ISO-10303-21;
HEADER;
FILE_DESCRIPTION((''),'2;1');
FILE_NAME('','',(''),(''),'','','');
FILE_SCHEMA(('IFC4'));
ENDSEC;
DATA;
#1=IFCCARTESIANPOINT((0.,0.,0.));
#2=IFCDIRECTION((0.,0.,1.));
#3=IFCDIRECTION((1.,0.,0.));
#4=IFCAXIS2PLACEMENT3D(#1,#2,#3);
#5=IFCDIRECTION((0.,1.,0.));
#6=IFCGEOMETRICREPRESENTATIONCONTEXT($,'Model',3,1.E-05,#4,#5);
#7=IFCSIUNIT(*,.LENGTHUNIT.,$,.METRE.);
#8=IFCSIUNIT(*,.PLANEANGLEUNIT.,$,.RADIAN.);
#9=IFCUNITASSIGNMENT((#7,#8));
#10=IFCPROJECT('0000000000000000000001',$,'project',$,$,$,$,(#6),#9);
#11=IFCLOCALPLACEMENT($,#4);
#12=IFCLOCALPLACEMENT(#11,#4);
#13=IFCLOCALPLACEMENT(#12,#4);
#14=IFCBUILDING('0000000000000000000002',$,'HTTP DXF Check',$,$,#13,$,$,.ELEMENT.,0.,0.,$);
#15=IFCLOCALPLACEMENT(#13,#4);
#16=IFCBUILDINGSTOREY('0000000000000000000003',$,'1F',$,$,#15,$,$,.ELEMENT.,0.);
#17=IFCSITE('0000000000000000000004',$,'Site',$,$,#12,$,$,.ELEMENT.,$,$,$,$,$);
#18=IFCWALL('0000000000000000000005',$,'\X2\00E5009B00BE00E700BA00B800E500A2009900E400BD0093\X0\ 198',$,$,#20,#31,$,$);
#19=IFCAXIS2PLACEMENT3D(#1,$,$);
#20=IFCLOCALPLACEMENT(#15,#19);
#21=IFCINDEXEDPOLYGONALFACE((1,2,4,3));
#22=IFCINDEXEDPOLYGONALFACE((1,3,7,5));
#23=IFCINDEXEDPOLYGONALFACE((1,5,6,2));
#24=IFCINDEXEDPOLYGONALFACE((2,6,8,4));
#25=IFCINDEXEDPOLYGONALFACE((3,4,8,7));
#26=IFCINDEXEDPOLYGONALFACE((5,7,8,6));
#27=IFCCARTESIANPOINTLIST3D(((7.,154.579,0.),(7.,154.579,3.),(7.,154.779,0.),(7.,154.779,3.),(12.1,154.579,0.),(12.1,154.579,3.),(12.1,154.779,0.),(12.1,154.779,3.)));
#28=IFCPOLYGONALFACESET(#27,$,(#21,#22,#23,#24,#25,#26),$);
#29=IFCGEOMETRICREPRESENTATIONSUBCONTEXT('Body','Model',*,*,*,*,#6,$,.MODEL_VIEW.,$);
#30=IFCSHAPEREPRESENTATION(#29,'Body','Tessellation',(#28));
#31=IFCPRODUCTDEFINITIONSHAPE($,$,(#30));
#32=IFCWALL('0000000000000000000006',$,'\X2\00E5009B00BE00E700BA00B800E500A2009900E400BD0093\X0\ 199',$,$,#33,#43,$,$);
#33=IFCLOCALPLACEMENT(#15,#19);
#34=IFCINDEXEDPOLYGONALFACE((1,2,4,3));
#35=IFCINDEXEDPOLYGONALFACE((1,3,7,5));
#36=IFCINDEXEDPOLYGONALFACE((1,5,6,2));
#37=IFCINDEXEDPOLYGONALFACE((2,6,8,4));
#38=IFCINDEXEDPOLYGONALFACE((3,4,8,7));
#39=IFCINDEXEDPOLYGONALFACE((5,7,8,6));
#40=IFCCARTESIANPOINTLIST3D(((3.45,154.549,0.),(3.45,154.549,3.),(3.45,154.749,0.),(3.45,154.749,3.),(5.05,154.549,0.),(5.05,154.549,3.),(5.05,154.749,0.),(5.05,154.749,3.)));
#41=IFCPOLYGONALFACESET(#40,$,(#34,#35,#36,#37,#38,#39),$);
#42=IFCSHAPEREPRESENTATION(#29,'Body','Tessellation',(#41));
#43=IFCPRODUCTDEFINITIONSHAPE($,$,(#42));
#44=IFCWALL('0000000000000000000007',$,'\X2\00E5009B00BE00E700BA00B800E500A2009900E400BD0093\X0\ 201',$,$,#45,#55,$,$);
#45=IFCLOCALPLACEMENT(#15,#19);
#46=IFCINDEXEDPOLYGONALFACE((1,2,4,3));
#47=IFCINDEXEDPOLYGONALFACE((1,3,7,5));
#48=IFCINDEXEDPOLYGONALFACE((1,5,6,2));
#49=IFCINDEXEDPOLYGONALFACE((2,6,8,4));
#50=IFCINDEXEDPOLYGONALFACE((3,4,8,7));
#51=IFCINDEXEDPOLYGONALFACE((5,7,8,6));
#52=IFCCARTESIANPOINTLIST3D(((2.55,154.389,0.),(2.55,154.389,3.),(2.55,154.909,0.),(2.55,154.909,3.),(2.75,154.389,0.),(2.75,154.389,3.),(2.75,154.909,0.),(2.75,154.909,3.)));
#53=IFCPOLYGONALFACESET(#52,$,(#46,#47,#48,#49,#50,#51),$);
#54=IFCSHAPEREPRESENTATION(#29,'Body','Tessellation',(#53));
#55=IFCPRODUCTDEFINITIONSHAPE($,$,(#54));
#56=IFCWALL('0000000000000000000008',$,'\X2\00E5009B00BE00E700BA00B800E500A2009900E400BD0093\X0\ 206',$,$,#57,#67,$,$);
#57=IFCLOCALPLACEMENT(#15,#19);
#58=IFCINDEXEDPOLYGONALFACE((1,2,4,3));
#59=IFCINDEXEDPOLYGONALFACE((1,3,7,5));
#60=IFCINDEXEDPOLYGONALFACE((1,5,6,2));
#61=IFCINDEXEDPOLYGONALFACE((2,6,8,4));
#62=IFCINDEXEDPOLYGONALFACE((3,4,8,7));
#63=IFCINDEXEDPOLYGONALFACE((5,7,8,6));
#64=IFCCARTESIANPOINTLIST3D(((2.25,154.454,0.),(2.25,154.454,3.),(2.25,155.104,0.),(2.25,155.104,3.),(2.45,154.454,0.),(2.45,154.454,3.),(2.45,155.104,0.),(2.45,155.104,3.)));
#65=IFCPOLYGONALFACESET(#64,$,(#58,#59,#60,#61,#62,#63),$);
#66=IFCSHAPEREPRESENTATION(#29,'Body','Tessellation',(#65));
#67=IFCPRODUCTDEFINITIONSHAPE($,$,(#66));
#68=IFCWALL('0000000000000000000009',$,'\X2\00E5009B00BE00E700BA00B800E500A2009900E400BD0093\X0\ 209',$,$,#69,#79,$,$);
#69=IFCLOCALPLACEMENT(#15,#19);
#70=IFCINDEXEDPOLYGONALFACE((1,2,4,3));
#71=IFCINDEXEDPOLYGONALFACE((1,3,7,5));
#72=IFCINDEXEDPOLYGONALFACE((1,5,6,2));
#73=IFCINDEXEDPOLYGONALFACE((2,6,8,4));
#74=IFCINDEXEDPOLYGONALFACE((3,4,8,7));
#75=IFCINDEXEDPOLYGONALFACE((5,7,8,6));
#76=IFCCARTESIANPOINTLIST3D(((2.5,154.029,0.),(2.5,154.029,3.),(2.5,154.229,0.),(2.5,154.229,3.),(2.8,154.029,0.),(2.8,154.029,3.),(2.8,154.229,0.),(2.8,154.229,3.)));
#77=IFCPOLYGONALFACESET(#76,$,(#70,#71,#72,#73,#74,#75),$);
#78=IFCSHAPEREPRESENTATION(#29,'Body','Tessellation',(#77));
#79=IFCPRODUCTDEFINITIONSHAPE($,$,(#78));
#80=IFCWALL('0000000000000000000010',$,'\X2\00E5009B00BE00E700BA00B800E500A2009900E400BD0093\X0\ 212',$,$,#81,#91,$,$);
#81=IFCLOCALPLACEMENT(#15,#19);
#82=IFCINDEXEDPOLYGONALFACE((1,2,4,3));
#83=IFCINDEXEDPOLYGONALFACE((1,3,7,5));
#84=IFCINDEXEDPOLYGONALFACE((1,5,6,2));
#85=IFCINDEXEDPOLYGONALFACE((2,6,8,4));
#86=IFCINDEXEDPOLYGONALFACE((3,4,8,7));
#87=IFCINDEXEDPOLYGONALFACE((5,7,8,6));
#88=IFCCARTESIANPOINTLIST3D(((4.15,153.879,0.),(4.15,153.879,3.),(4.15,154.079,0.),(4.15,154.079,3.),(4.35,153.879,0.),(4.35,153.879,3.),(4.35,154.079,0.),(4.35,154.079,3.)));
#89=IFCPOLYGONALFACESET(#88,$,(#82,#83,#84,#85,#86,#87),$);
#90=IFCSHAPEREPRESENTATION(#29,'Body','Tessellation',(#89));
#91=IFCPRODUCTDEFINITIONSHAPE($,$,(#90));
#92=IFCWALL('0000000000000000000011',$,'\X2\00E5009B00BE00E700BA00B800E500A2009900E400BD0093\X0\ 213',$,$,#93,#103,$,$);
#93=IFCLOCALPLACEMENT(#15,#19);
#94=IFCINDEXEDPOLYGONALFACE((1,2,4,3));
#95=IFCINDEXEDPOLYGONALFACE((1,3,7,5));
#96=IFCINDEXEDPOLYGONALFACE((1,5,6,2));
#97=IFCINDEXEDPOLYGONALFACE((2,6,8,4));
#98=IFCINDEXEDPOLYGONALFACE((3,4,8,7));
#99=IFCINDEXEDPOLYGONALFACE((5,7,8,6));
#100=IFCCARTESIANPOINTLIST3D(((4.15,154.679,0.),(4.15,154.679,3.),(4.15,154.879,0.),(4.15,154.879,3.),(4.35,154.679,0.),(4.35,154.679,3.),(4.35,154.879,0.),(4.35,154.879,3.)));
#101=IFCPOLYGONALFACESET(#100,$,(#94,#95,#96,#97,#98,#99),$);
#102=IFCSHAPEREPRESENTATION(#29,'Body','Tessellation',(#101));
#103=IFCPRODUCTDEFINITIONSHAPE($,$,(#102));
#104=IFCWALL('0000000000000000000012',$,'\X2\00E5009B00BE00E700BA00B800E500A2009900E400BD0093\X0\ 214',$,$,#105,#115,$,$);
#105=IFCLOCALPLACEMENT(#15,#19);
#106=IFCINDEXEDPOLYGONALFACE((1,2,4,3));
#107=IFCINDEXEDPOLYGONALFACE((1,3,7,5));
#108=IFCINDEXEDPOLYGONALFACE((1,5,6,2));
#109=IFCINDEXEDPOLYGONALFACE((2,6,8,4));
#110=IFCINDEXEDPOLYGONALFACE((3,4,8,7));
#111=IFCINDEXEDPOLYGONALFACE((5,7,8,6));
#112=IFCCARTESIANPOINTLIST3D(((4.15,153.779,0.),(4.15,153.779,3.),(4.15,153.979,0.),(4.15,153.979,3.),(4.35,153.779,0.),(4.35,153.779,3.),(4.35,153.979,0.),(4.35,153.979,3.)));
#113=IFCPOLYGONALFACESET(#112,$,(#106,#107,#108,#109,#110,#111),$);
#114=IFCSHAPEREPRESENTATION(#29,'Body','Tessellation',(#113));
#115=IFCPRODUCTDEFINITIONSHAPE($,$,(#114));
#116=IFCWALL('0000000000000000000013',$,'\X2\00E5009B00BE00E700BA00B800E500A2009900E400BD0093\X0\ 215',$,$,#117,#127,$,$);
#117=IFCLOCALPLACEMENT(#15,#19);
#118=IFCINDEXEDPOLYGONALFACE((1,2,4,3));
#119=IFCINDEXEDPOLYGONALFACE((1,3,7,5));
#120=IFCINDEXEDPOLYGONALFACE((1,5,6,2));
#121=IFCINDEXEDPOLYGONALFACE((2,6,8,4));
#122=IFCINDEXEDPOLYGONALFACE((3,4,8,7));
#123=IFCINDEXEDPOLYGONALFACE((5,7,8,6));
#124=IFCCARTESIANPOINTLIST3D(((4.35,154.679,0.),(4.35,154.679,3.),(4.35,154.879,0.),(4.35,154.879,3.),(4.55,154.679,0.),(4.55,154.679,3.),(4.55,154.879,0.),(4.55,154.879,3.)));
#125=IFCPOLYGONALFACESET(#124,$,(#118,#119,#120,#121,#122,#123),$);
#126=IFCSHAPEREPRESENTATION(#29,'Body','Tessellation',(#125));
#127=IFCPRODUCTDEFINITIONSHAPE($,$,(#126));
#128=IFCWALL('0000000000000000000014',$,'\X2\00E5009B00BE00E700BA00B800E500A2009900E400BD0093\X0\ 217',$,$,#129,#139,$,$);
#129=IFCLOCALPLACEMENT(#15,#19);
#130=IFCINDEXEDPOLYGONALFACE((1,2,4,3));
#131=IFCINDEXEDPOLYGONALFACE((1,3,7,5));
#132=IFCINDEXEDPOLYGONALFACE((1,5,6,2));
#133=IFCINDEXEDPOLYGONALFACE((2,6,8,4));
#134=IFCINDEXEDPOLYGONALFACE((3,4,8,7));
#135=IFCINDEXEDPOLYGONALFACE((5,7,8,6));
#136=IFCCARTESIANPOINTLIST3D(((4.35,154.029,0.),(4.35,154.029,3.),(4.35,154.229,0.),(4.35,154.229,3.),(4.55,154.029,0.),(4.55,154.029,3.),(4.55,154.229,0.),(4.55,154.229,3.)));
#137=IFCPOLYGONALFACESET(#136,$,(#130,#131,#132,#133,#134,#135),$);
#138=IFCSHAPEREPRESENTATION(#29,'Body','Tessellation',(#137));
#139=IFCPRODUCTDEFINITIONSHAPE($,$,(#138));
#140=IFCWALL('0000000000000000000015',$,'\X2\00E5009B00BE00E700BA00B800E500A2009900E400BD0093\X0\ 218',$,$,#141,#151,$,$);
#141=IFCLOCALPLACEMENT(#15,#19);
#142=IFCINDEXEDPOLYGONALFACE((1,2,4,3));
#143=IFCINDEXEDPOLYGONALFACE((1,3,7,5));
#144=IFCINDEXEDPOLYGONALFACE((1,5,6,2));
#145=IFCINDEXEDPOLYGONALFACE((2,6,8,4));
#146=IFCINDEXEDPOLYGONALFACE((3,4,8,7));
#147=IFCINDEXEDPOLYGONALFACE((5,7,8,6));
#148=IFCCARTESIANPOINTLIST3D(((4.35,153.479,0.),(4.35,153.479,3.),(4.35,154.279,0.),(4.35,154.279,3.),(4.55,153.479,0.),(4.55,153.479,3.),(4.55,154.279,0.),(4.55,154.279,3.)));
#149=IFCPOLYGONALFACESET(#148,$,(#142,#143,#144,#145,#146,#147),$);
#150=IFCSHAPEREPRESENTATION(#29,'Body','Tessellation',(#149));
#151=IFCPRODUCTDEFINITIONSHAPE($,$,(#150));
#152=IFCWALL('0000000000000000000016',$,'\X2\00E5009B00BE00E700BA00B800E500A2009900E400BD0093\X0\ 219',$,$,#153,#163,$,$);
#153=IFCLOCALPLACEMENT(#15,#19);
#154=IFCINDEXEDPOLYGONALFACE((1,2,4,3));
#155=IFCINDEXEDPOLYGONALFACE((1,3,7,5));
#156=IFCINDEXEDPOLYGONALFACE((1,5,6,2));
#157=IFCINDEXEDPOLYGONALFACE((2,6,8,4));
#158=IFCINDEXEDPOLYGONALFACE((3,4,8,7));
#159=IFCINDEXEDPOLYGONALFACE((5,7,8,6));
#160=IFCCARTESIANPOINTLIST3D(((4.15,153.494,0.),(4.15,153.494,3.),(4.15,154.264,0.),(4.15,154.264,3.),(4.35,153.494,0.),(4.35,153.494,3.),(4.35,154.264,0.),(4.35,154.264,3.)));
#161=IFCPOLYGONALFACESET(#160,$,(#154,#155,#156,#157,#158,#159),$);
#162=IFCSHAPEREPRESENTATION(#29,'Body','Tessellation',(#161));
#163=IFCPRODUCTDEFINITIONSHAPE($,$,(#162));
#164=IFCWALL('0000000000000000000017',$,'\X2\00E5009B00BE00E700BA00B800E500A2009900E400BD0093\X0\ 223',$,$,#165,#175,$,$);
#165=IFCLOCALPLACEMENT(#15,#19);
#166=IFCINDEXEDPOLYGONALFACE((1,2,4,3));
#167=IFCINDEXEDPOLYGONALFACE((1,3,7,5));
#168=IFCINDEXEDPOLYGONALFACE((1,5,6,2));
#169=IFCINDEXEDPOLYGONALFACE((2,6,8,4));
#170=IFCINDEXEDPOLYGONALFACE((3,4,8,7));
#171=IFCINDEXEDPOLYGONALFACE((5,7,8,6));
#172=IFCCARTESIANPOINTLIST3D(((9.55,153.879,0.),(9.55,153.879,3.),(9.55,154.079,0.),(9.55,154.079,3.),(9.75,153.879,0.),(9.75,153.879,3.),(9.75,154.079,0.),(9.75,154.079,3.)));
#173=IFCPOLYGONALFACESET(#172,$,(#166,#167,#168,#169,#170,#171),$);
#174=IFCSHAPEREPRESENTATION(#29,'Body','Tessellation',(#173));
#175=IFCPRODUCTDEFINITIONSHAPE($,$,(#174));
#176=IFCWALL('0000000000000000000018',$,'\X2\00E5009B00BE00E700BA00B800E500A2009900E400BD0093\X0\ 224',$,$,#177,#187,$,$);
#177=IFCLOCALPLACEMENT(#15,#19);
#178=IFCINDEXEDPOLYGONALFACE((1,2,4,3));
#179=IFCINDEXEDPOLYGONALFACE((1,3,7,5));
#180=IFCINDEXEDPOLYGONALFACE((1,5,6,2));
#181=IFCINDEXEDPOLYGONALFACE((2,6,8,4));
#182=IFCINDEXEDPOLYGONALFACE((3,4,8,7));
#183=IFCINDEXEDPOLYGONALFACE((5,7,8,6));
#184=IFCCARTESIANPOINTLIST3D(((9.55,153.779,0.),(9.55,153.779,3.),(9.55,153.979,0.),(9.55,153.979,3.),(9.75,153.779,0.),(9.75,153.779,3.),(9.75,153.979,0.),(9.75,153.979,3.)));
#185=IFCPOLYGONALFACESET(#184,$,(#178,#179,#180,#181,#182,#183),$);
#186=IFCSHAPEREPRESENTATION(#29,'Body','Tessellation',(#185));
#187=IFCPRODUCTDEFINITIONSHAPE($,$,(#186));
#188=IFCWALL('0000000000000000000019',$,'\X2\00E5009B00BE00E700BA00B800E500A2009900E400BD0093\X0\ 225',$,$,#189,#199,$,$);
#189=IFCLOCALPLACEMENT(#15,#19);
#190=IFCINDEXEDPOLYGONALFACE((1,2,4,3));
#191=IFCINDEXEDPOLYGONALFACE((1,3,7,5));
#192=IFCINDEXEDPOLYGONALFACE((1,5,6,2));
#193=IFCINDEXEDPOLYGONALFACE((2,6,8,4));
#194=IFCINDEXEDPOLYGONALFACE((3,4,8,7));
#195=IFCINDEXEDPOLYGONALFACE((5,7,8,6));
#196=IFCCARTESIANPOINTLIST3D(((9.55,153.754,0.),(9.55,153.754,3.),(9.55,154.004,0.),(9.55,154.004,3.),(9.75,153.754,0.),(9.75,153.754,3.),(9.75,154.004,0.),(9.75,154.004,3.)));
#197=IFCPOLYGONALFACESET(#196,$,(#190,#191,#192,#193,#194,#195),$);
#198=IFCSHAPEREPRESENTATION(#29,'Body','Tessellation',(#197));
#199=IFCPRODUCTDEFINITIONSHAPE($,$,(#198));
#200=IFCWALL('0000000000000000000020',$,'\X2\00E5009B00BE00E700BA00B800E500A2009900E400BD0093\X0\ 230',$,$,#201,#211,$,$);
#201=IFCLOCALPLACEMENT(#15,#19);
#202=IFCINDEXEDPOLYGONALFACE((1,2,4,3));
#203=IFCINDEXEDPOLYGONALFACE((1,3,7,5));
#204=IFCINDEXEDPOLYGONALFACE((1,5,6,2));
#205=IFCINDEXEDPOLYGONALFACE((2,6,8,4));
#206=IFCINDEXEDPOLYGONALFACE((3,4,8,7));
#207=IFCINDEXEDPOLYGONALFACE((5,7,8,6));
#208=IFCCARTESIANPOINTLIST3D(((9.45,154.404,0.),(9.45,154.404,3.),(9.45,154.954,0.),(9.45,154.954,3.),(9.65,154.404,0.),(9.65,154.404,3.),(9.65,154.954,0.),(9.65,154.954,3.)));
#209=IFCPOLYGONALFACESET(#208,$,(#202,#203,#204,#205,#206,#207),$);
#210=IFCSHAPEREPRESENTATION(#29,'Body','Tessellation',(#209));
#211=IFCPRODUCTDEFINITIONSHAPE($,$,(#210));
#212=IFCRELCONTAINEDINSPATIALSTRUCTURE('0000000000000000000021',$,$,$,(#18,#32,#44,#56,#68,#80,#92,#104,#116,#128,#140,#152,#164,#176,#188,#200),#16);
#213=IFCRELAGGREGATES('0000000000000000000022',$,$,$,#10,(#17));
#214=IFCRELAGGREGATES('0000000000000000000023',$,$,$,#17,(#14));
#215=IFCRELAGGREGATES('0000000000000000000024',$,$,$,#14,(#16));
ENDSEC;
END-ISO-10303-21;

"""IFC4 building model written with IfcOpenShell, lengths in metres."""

from ifc_helpers import new_model, si_unit, direction, frame, frame_2d, origin_with_axes, place, context, subcontext, project, spatial, rectangle, extrude, element, save


model = new_model("IFC4")

# Units and contexts
model_context = context("Model", 3, precision=1e-05, world=origin_with_axes(), true_north=direction((0.0, 1.0, 0.0)))
body_context = subcontext(model_context, "Body", "Model", "MODEL_VIEW")
ifc_project = project(units=[si_unit("LENGTHUNIT", "METRE"), si_unit("PLANEANGLEUNIT", "RADIAN")], contexts=[model_context])

# Site, building, storey
placement = place(None, origin_with_axes())
site_placement = place(placement, origin_with_axes())
site = spatial("IfcSite", under=ifc_project, at=site_placement, Name="Site", CompositionType="ELEMENT")
building_placement = place(site_placement, origin_with_axes())
building = spatial("IfcBuilding", under=site, at=building_placement, Name="HTTP DXF Check", CompositionType="ELEMENT", ElevationOfRefHeight=0.0, ElevationOfTerrain=0.0)
storey_placement = place(building_placement, origin_with_axes())
storey = spatial("IfcBuildingStorey", under=building, at=storey_placement, Name="1F", CompositionType="ELEMENT", Elevation=0.0)

# Walls
wall_1_placement = place(storey_placement, frame((9.55, 154.679, 0.0), z_axis=(0.0, 0.0, 1.0), x_axis=(-1.0, 0.0, 0.0)))
element("IfcWall", 1, at=wall_1_placement, inside=storey, Name="å\u009b¾çº¸å¢\u0099ä½\u0093 198", context=body_context, shape_type="SweptSolid", body=[
    extrude(rectangle(XDim=5.1, YDim=0.2, at=frame_2d((0.0, 0.0), x_axis=(1.0, 0.0, 0.0))), frame((0.0, 0.0, 0.0), z_axis=(0.0, 0.0, 1.0)), (0.0, 0.0, 1.0), 3.0),
])
wall_2_placement = place(storey_placement, frame((4.25, 154.649, 0.0), z_axis=(0.0, 0.0, 1.0), x_axis=(-1.0, 0.0, 0.0)))
element("IfcWall", 2, at=wall_2_placement, inside=storey, Name="å\u009b¾çº¸å¢\u0099ä½\u0093 199", context=body_context, shape_type="SweptSolid", body=[
    extrude(rectangle(XDim=1.6, YDim=0.2, at=frame_2d((0.0, 0.0), x_axis=(1.0, 0.0, 0.0))), frame((0.0, 0.0, 0.0), z_axis=(0.0, 0.0, 1.0)), (0.0, 0.0, 1.0), 3.0),
])
wall_3_placement = place(storey_placement, frame((2.65, 154.649, 0.0), z_axis=(0.0, 0.0, 1.0), x_axis=(0.0, -1.0, 0.0)))
element("IfcWall", 3, at=wall_3_placement, inside=storey, Name="å\u009b¾çº¸å¢\u0099ä½\u0093 201", context=body_context, shape_type="SweptSolid", body=[
    extrude(rectangle(XDim=0.52, YDim=0.2, at=frame_2d((0.0, 0.0), x_axis=(1.0, 0.0, 0.0))), frame((0.0, 0.0, 0.0), z_axis=(0.0, 0.0, 1.0)), (0.0, 0.0, 1.0), 3.0),
])
wall_4_placement = place(storey_placement, frame((2.35, 154.779, 0.0), z_axis=(0.0, 0.0, 1.0), x_axis=(0.0, -1.0, 0.0)))
element("IfcWall", 4, at=wall_4_placement, inside=storey, Name="å\u009b¾çº¸å¢\u0099ä½\u0093 206", context=body_context, shape_type="SweptSolid", body=[
    extrude(rectangle(XDim=0.65, YDim=0.2, at=frame_2d((0.0, 0.0), x_axis=(1.0, 0.0, 0.0))), frame((0.0, 0.0, 0.0), z_axis=(0.0, 0.0, 1.0)), (0.0, 0.0, 1.0), 3.0),
])
wall_5_placement = place(storey_placement, frame((2.65, 154.129, 0.0), z_axis=(0.0, 0.0, 1.0), x_axis=(-1.0, 0.0, 0.0)))
element("IfcWall", 5, at=wall_5_placement, inside=storey, Name="å\u009b¾çº¸å¢\u0099ä½\u0093 209", context=body_context, shape_type="SweptSolid", body=[
    extrude(rectangle(XDim=0.3, YDim=0.2, at=frame_2d((0.0, 0.0), x_axis=(1.0, 0.0, 0.0))), frame((0.0, 0.0, 0.0), z_axis=(0.0, 0.0, 1.0)), (0.0, 0.0, 1.0), 3.0),
])
for number, where, z_axis, x_axis, name in (
    (6, (4.25, 153.979, 0.0), (0.0, 0.0, 1.0), (1.0, 0.0, 0.0), "å\u009b¾çº¸å¢\u0099ä½\u0093 212"),
    (7, (4.25, 154.779, 0.0), (0.0, 0.0, 1.0), (1.0, 0.0, 0.0), "å\u009b¾çº¸å¢\u0099ä½\u0093 213"),
    (8, (4.25, 153.879, 0.0), (0.0, 0.0, 1.0), (1.0, 0.0, 0.0), "å\u009b¾çº¸å¢\u0099ä½\u0093 214"),
    (9, (4.45, 154.779, 0.0), (0.0, 0.0, 1.0), (-1.0, 0.0, 0.0), "å\u009b¾çº¸å¢\u0099ä½\u0093 215"),
    (10, (4.45, 154.129, 0.0), (0.0, 0.0, 1.0), (-1.0, 0.0, 0.0), "å\u009b¾çº¸å¢\u0099ä½\u0093 217"),
):
    element("IfcWall", number, at=place(storey_placement, frame(where, z_axis=z_axis, x_axis=x_axis)), inside=storey, Name=name, context=body_context, shape_type="SweptSolid", body=[
        extrude(rectangle(XDim=0.2, YDim=0.2, at=frame_2d((0.0, 0.0), x_axis=(1.0, 0.0, 0.0))), frame((0.0, 0.0, 0.0), z_axis=(0.0, 0.0, 1.0)), (0.0, 0.0, 1.0), 3.0),
    ])
wall_6_placement = place(storey_placement, frame((4.45, 153.879, 0.0), z_axis=(0.0, 0.0, 1.0), x_axis=(0.0, 1.0, 0.0)))
element("IfcWall", 11, at=wall_6_placement, inside=storey, Name="å\u009b¾çº¸å¢\u0099ä½\u0093 218", context=body_context, shape_type="SweptSolid", body=[
    extrude(rectangle(XDim=0.8, YDim=0.2, at=frame_2d((0.0, 0.0), x_axis=(1.0, 0.0, 0.0))), frame((0.0, 0.0, 0.0), z_axis=(0.0, 0.0, 1.0)), (0.0, 0.0, 1.0), 3.0),
])
wall_7_placement = place(storey_placement, frame((4.25, 153.879, 0.0), z_axis=(0.0, 0.0, 1.0), x_axis=(0.0, 1.0, 0.0)))
element("IfcWall", 12, at=wall_7_placement, inside=storey, Name="å\u009b¾çº¸å¢\u0099ä½\u0093 219", context=body_context, shape_type="SweptSolid", body=[
    extrude(rectangle(XDim=0.77, YDim=0.2, at=frame_2d((0.0, 0.0), x_axis=(1.0, 0.0, 0.0))), frame((0.0, 0.0, 0.0), z_axis=(0.0, 0.0, 1.0)), (0.0, 0.0, 1.0), 3.0),
])
for number, where, z_axis, x_axis, name in (
    (13, (9.65, 153.979, 0.0), (0.0, 0.0, 1.0), (1.0, 0.0, 0.0), "å\u009b¾çº¸å¢\u0099ä½\u0093 223"),
    (14, (9.65, 153.879, 0.0), (0.0, 0.0, 1.0), (1.0, 0.0, 0.0), "å\u009b¾çº¸å¢\u0099ä½\u0093 224"),
):
    element("IfcWall", number, at=place(storey_placement, frame(where, z_axis=z_axis, x_axis=x_axis)), inside=storey, Name=name, context=body_context, shape_type="SweptSolid", body=[
        extrude(rectangle(XDim=0.2, YDim=0.2, at=frame_2d((0.0, 0.0), x_axis=(1.0, 0.0, 0.0))), frame((0.0, 0.0, 0.0), z_axis=(0.0, 0.0, 1.0)), (0.0, 0.0, 1.0), 3.0),
    ])
wall_8_placement = place(storey_placement, frame((9.65, 153.879, 0.0), z_axis=(0.0, 0.0, 1.0), x_axis=(0.0, 1.0, 0.0)))
element("IfcWall", 15, at=wall_8_placement, inside=storey, Name="å\u009b¾çº¸å¢\u0099ä½\u0093 225", context=body_context, shape_type="SweptSolid", body=[
    extrude(rectangle(XDim=0.25, YDim=0.2, at=frame_2d((0.0, 0.0), x_axis=(1.0, 0.0, 0.0))), frame((0.0, 0.0, 0.0), z_axis=(0.0, 0.0, 1.0)), (0.0, 0.0, 1.0), 3.0),
])
wall_9_placement = place(storey_placement, frame((9.55, 154.679, 0.0), z_axis=(0.0, 0.0, 1.0), x_axis=(0.0, -1.0, 0.0)))
element("IfcWall", 16, at=wall_9_placement, inside=storey, Name="å\u009b¾çº¸å¢\u0099ä½\u0093 230", context=body_context, shape_type="SweptSolid", body=[
    extrude(rectangle(XDim=0.55, YDim=0.2, at=frame_2d((0.0, 0.0), x_axis=(1.0, 0.0, 0.0))), frame((0.0, 0.0, 0.0), z_axis=(0.0, 0.0, 1.0)), (0.0, 0.0, 1.0), 3.0),
])

save(model, "model.ifc")
